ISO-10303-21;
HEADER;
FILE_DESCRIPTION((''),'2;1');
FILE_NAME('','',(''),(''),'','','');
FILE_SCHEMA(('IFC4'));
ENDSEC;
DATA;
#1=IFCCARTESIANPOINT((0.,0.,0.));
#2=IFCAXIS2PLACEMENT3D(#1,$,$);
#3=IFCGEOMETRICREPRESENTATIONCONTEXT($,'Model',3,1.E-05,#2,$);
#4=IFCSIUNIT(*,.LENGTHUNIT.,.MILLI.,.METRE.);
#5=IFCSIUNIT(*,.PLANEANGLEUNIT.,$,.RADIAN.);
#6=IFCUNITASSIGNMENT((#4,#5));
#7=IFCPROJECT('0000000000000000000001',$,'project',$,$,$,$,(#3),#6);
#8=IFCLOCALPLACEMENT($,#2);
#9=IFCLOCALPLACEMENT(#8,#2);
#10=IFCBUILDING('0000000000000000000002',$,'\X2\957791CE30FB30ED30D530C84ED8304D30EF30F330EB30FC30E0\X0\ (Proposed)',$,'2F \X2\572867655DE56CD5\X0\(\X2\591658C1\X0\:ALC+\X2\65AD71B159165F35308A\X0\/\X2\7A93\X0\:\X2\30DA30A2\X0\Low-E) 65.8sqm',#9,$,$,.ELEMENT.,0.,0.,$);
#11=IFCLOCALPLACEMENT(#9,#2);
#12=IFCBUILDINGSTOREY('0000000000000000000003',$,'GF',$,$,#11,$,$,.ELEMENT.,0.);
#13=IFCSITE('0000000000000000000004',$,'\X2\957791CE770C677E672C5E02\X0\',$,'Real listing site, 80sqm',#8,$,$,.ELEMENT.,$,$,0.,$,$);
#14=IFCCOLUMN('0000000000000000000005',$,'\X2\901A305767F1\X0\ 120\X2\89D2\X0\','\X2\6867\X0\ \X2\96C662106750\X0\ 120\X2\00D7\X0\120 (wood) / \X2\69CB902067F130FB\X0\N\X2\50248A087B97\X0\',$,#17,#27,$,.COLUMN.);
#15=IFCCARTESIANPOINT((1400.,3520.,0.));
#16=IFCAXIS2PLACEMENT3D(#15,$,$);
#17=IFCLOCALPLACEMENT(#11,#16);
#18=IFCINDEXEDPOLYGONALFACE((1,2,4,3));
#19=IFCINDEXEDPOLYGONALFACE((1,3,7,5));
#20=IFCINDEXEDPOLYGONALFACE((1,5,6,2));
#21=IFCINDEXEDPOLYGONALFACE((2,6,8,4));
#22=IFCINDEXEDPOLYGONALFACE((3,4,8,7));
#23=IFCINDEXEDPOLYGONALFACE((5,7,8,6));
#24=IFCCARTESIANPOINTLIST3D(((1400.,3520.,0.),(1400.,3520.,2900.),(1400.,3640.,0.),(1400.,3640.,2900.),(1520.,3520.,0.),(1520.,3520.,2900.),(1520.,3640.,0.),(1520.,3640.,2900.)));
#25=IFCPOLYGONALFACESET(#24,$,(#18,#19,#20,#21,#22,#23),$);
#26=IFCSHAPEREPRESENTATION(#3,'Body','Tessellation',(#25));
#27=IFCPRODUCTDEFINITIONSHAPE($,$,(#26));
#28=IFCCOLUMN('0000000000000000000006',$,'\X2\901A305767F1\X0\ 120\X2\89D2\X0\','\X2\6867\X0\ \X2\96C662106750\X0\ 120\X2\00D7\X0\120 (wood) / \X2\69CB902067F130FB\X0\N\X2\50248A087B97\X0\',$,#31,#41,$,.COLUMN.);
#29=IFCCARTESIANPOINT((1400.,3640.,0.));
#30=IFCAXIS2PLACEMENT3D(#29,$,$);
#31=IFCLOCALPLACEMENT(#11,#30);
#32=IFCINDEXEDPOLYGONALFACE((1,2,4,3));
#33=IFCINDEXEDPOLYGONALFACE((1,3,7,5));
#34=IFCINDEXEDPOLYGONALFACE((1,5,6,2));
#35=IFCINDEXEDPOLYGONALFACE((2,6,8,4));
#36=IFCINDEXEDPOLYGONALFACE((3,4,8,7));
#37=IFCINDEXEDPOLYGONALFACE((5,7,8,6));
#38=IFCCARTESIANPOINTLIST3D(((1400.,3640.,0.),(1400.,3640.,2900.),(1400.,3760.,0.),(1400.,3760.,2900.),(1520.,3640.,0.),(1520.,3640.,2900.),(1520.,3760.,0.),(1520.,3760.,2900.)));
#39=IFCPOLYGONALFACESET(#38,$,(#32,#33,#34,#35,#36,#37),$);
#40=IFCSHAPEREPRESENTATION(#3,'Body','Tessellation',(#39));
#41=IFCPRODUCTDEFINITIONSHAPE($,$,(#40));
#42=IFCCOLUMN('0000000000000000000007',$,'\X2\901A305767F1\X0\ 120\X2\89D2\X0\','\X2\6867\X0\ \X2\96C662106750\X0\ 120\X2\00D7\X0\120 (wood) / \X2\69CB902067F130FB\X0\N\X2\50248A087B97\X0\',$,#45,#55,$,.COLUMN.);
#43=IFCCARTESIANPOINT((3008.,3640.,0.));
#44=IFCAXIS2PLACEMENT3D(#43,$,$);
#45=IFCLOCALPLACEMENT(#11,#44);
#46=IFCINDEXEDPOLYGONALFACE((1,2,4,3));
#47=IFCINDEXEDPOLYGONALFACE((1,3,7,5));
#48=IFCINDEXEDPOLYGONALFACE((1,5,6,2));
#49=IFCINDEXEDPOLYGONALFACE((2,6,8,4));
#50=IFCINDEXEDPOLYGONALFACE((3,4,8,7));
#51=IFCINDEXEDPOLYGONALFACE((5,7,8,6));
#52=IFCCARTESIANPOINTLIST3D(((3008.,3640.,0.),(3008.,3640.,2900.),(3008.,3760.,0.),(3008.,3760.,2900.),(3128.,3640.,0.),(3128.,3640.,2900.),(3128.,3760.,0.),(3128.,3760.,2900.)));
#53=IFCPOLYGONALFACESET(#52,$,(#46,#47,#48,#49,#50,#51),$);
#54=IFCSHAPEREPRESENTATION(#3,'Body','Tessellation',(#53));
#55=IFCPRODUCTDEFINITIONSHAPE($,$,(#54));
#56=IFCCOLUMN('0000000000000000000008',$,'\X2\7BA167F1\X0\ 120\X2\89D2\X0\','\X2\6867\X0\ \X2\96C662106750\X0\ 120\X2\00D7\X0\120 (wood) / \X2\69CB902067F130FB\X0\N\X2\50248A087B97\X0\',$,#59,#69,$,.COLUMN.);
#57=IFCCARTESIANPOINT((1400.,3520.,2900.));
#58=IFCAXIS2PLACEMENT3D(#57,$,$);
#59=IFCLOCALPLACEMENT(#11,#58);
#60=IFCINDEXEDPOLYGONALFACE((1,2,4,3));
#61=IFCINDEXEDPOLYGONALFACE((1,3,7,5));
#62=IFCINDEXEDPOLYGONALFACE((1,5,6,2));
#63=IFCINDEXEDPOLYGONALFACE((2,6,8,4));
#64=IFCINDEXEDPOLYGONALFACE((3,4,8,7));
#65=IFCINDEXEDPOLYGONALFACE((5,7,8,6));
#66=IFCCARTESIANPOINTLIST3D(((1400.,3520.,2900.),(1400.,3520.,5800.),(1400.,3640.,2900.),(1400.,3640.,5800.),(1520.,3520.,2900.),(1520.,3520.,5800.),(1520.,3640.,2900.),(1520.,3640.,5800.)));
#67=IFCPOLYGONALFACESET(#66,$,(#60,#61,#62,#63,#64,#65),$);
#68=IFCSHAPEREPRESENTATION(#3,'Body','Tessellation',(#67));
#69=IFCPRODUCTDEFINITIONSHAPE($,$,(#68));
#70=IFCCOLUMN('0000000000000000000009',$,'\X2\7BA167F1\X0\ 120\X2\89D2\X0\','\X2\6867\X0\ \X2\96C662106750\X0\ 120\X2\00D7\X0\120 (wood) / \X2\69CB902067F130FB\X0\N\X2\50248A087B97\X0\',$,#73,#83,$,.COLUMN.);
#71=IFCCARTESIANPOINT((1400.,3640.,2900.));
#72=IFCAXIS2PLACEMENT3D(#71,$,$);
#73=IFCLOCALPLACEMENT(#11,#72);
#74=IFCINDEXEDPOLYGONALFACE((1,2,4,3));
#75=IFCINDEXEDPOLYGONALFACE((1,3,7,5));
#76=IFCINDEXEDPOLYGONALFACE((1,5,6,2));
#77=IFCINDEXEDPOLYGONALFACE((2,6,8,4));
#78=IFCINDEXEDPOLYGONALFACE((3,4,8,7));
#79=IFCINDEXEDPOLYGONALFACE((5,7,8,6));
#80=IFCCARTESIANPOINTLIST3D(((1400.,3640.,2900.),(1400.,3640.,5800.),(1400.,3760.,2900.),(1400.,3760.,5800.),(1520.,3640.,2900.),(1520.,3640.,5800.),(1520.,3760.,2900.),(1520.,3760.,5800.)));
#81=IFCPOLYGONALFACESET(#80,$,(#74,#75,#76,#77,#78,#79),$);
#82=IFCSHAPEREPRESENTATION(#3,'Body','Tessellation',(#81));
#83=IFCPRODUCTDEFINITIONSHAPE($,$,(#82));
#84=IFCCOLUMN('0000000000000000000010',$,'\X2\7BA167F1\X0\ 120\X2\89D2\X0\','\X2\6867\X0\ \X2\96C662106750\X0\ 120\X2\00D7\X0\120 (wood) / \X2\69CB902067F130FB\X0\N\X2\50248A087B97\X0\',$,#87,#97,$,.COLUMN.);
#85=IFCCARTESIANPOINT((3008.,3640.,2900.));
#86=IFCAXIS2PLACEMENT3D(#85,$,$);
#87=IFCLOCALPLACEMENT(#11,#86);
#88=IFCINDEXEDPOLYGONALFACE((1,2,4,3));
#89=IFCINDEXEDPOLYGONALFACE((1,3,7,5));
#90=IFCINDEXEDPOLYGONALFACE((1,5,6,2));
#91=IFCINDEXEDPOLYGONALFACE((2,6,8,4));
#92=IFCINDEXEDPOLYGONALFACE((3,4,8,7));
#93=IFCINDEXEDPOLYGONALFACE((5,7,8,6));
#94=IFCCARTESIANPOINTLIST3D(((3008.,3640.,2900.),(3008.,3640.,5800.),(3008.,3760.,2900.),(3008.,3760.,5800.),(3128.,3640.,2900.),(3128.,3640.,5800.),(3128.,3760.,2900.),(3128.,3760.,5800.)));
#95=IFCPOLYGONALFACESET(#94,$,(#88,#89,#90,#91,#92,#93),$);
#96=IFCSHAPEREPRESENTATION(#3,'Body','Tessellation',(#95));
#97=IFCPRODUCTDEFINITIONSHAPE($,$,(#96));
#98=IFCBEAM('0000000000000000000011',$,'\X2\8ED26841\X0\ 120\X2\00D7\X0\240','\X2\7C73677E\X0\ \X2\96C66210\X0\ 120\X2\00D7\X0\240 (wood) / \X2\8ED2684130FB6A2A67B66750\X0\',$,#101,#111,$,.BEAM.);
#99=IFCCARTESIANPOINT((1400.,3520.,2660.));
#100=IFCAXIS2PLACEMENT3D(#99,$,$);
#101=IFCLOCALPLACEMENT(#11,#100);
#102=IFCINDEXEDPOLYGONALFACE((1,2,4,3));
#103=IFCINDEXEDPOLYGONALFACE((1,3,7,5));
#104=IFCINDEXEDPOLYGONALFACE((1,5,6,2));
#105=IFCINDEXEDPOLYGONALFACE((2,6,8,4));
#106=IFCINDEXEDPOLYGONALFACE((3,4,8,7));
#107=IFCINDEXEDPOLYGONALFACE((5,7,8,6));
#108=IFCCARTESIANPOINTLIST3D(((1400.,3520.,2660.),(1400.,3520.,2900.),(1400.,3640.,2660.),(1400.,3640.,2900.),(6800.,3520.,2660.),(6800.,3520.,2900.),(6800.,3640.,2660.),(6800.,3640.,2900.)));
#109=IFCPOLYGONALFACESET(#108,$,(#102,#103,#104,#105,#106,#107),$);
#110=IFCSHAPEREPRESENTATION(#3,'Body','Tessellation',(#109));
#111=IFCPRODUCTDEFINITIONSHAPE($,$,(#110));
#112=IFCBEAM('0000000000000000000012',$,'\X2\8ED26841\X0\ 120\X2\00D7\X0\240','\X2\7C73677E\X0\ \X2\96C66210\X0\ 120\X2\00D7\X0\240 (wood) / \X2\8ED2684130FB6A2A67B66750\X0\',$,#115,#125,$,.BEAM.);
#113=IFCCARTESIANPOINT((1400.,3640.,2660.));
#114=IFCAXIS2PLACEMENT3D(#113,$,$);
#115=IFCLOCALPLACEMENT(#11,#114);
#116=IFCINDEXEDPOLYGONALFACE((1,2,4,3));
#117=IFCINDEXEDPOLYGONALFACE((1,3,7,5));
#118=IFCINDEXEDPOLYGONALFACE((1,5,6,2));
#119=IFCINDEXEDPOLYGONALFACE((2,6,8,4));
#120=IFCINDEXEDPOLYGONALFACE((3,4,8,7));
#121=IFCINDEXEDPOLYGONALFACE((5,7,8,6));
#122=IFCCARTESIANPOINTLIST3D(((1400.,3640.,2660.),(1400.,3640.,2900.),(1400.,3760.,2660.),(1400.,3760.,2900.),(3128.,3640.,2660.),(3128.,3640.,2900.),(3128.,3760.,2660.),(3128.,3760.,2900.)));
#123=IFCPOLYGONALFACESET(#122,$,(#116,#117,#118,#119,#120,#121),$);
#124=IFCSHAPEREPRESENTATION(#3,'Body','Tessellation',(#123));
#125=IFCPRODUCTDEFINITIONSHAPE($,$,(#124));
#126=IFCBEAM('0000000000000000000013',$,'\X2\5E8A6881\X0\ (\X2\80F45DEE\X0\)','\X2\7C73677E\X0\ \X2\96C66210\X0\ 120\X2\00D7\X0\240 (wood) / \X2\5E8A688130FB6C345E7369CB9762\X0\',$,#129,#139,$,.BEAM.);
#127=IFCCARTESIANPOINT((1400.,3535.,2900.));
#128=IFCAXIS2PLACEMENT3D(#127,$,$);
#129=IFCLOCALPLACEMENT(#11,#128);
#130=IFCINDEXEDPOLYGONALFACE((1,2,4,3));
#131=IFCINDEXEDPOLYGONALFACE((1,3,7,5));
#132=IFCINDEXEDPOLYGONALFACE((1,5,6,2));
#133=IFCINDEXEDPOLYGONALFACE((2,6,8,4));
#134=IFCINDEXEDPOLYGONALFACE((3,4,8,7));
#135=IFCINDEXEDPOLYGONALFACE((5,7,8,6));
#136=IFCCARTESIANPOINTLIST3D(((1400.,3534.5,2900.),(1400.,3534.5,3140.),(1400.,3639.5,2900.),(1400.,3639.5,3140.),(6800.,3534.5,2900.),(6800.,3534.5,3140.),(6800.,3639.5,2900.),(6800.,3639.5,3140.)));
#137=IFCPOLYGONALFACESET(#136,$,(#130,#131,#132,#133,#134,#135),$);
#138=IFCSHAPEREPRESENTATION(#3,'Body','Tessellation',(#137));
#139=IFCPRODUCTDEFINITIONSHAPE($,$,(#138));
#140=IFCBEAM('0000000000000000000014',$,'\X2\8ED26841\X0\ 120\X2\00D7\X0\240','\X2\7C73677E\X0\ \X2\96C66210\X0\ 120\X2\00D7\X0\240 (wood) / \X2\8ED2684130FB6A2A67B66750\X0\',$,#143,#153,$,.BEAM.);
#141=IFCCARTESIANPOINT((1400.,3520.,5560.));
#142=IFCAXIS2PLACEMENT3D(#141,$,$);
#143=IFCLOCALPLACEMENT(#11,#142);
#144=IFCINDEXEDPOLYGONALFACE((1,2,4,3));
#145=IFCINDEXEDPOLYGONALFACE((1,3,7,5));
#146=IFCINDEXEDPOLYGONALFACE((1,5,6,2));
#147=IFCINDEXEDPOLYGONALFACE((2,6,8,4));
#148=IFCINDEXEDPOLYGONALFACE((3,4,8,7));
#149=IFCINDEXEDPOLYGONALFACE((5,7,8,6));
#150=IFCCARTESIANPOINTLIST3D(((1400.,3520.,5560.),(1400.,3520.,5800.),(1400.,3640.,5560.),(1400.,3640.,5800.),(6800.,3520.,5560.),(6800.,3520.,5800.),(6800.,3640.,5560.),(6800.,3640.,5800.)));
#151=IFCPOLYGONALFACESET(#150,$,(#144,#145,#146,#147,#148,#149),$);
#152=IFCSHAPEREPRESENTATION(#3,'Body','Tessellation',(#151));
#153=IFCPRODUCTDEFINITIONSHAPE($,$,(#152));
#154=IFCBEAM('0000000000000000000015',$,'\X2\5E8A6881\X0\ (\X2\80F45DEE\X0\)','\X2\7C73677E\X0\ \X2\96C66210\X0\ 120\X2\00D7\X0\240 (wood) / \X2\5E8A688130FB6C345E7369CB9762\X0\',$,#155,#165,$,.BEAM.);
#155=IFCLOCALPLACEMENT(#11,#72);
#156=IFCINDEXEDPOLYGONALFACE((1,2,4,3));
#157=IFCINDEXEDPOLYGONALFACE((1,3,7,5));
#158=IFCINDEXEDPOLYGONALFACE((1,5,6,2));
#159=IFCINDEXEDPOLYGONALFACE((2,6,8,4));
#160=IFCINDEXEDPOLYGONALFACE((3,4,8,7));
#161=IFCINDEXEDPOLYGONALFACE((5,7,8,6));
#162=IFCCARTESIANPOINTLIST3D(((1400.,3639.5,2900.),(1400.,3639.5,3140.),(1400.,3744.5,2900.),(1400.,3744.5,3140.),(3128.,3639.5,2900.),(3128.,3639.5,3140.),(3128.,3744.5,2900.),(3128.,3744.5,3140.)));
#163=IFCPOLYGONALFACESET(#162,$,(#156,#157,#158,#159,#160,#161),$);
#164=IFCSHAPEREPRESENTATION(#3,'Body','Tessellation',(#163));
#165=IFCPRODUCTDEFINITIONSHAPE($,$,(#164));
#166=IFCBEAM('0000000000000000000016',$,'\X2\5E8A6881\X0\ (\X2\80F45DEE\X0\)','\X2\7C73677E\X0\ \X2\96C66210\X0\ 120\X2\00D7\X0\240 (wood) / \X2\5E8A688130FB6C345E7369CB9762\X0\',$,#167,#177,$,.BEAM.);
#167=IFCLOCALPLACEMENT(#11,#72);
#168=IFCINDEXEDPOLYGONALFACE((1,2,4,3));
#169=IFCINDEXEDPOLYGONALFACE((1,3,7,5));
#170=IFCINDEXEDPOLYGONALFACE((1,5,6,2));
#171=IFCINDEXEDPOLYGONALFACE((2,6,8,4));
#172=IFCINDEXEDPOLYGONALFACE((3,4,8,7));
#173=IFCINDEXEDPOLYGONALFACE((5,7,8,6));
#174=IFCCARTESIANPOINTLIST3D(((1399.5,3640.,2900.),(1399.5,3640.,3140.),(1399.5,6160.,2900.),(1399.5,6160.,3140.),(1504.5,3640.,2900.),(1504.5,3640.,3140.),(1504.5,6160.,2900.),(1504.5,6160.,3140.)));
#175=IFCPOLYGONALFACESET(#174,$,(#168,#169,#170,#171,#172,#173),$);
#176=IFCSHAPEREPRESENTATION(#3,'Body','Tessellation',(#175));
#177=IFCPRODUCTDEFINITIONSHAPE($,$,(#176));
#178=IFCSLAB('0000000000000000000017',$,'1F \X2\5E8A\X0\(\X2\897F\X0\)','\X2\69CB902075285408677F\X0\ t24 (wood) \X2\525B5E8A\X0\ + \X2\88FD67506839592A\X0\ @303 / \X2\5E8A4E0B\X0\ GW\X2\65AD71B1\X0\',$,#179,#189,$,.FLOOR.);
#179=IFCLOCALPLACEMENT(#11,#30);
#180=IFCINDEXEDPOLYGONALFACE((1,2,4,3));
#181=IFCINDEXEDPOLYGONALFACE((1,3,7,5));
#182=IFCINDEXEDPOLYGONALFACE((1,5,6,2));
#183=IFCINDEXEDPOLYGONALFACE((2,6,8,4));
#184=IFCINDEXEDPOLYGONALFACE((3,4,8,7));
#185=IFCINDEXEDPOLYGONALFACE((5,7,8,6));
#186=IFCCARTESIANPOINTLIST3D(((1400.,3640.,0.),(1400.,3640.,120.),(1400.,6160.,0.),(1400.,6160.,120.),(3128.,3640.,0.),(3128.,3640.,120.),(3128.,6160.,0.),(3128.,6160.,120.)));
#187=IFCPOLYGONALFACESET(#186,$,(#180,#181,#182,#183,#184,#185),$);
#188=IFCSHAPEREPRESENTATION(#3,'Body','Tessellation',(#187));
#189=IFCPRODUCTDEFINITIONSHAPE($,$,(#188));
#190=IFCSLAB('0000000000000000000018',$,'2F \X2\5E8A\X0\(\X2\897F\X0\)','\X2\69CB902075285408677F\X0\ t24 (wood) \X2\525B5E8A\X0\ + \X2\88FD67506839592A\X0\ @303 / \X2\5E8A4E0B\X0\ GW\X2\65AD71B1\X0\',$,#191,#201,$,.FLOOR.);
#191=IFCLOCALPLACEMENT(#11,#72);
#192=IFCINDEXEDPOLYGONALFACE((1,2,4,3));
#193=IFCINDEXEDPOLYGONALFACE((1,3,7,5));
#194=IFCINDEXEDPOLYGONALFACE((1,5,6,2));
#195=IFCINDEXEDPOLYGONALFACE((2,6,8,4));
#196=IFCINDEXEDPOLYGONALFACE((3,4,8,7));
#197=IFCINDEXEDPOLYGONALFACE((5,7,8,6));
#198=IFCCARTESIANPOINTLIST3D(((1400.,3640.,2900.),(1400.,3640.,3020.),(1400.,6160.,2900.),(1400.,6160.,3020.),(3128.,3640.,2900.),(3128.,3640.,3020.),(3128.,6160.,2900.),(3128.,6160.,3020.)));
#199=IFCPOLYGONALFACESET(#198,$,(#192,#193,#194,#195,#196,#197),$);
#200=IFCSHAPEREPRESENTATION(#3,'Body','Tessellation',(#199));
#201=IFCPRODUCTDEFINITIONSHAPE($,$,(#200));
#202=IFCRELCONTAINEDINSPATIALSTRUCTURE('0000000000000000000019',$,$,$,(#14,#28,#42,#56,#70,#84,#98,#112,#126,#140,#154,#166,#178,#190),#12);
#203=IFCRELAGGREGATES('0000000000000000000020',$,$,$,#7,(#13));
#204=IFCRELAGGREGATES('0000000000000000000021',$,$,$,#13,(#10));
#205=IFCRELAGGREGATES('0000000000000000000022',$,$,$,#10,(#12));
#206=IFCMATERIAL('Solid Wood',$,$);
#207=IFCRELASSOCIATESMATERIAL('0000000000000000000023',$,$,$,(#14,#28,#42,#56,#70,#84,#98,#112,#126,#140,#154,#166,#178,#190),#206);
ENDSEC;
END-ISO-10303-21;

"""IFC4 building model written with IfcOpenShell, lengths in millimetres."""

from ifc_helpers import new_model, si_unit, frame, frame_2d, origin, place, context, project, spatial, rectangle, extrude, material, element, save


model = new_model("IFC4")

# Units and contexts
model_context = context("Model", 3, precision=1e-05, world=origin())
ifc_project = project(units=[si_unit("LENGTHUNIT", "METRE", prefix="MILLI"), si_unit("PLANEANGLEUNIT", "RADIAN")], contexts=[model_context])

# Site, building, storey
site_placement = place(None, origin())
site = spatial("IfcSite", under=ifc_project, at=site_placement, Name="長野県松本市", ObjectType="Real listing site, 80sqm", CompositionType="ELEMENT", RefElevation=0.0)
building_placement = place(site_placement, origin())
building = spatial("IfcBuilding", under=site, at=building_placement, Name="長野・ロフト付きワンルーム (Proposed)", ObjectType="2F 在来工法(外壁:ALC+断熱外張り/窓:ペアLow-E) 65.8sqm", CompositionType="ELEMENT", ElevationOfRefHeight=0.0, ElevationOfTerrain=0.0)
storey_placement = place(building_placement, origin())
storey = spatial("IfcBuildingStorey", under=building, at=storey_placement, Name="GF", CompositionType="ELEMENT", Elevation=0.0)

# Columns
ifc_material_1 = material(Name="Solid Wood")
column_1_placement = place(storey_placement, frame((1400.0, 3520.0, 0.0)))
element("IfcColumn", 1, at=column_1_placement, inside=storey, material=ifc_material_1, Name="通し柱 120角", Description="桧 集成材 120×120 (wood) / 構造柱・N値計算", PredefinedType="COLUMN", context=model_context, shape_type="SweptSolid", body=[
    extrude(rectangle(XDim=120.0, YDim=120.0, at=frame_2d((60.0, 60.0))), frame((1400.0, 3520.0, 0.0)), (0.0, 0.0, 1.0), 2900.0),
])
column_2_placement = place(storey_placement, frame((1400.0, 3640.0, 0.0)))
element("IfcColumn", 2, at=column_2_placement, inside=storey, material=ifc_material_1, Name="通し柱 120角", Description="桧 集成材 120×120 (wood) / 構造柱・N値計算", PredefinedType="COLUMN", context=model_context, shape_type="SweptSolid", body=[
    extrude(rectangle(XDim=120.0, YDim=120.0, at=frame_2d((60.0, 60.0))), frame((1400.0, 3640.0, 0.0)), (0.0, 0.0, 1.0), 2900.0),
])
column_3_placement = place(storey_placement, frame((3008.0, 3640.0, 0.0)))
element("IfcColumn", 3, at=column_3_placement, inside=storey, material=ifc_material_1, Name="通し柱 120角", Description="桧 集成材 120×120 (wood) / 構造柱・N値計算", PredefinedType="COLUMN", context=model_context, shape_type="SweptSolid", body=[
    extrude(rectangle(XDim=120.0, YDim=120.0, at=frame_2d((60.0, 60.0))), frame((3008.0, 3640.0, 0.0)), (0.0, 0.0, 1.0), 2900.0),
])
column_4_placement = place(storey_placement, frame((1400.0, 3520.0, 2900.0)))
element("IfcColumn", 4, at=column_4_placement, inside=storey, material=ifc_material_1, Name="管柱 120角", Description="桧 集成材 120×120 (wood) / 構造柱・N値計算", PredefinedType="COLUMN", context=model_context, shape_type="SweptSolid", body=[
    extrude(rectangle(XDim=120.0, YDim=120.0, at=frame_2d((60.0, 60.0))), frame((1400.0, 3520.0, 2900.0)), (0.0, 0.0, 1.0), 2900.0),
])
column_5_placement = place(storey_placement, frame((1400.0, 3640.0, 2900.0)))
element("IfcColumn", 5, at=column_5_placement, inside=storey, material=ifc_material_1, Name="管柱 120角", Description="桧 集成材 120×120 (wood) / 構造柱・N値計算", PredefinedType="COLUMN", context=model_context, shape_type="SweptSolid", body=[
    extrude(rectangle(XDim=120.0, YDim=120.0, at=frame_2d((60.0, 60.0))), frame((1400.0, 3640.0, 2900.0)), (0.0, 0.0, 1.0), 2900.0),
])
column_6_placement = place(storey_placement, frame((3008.0, 3640.0, 2900.0)))
element("IfcColumn", 6, at=column_6_placement, inside=storey, material=ifc_material_1, Name="管柱 120角", Description="桧 集成材 120×120 (wood) / 構造柱・N値計算", PredefinedType="COLUMN", context=model_context, shape_type="SweptSolid", body=[
    extrude(rectangle(XDim=120.0, YDim=120.0, at=frame_2d((60.0, 60.0))), frame((3008.0, 3640.0, 2900.0)), (0.0, 0.0, 1.0), 2900.0),
])

# Beams
beam_1_placement = place(storey_placement, frame((1400.0, 3520.0, 2660.0)))
element("IfcBeam", 7, at=beam_1_placement, inside=storey, material=ifc_material_1, Name="軒桁 120×240", Description="米松 集成 120×240 (wood) / 軒桁・横架材", PredefinedType="BEAM", context=model_context, shape_type="SweptSolid", body=[
    extrude(rectangle(XDim=5400.0, YDim=120.0, at=frame_2d((2700.0, 60.0))), frame((1400.0, 3520.0, 2660.0)), (0.0, 0.0, 1.0), 240.0),
])
beam_2_placement = place(storey_placement, frame((1400.0, 3640.0, 2660.0)))
element("IfcBeam", 8, at=beam_2_placement, inside=storey, material=ifc_material_1, Name="軒桁 120×240", Description="米松 集成 120×240 (wood) / 軒桁・横架材", PredefinedType="BEAM", context=model_context, shape_type="SweptSolid", body=[
    extrude(rectangle(XDim=1728.0, YDim=120.0, at=frame_2d((864.0, 60.0))), frame((1400.0, 3640.0, 2660.0)), (0.0, 0.0, 1.0), 240.0),
])
beam_3_placement = place(storey_placement, frame((1400.0, 3535.0, 2900.0)))
element("IfcBeam", 9, at=beam_3_placement, inside=storey, material=ifc_material_1, Name="床梁 (胴差)", Description="米松 集成 120×240 (wood) / 床梁・水平構面", PredefinedType="BEAM", context=model_context, shape_type="SweptSolid", body=[
    extrude(rectangle(XDim=5400.0, YDim=105.0, at=frame_2d((2700.0, 52.0))), frame((1400.0, 3535.0, 2900.0)), (0.0, 0.0, 1.0), 240.0),
])
beam_4_placement = place(storey_placement, frame((1400.0, 3520.0, 5560.0)))
element("IfcBeam", 10, at=beam_4_placement, inside=storey, material=ifc_material_1, Name="軒桁 120×240", Description="米松 集成 120×240 (wood) / 軒桁・横架材", PredefinedType="BEAM", context=model_context, shape_type="SweptSolid", body=[
    extrude(rectangle(XDim=5400.0, YDim=120.0, at=frame_2d((2700.0, 60.0))), frame((1400.0, 3520.0, 5560.0)), (0.0, 0.0, 1.0), 240.0),
])
beam_5_placement = place(storey_placement, frame((1400.0, 3640.0, 2900.0)))
element("IfcBeam", 11, at=beam_5_placement, inside=storey, material=ifc_material_1, Name="床梁 (胴差)", Description="米松 集成 120×240 (wood) / 床梁・水平構面", PredefinedType="BEAM", context=model_context, shape_type="SweptSolid", body=[
    extrude(rectangle(XDim=1728.0, YDim=105.0, at=frame_2d((864.0, 52.0))), frame((1400.0, 3640.0, 2900.0)), (0.0, 0.0, 1.0), 240.0),
])
beam_6_placement = place(storey_placement, frame((1400.0, 3640.0, 2900.0)))
element("IfcBeam", 12, at=beam_6_placement, inside=storey, material=ifc_material_1, Name="床梁 (胴差)", Description="米松 集成 120×240 (wood) / 床梁・水平構面", PredefinedType="BEAM", context=model_context, shape_type="SweptSolid", body=[
    extrude(rectangle(XDim=105.0, YDim=2520.0, at=frame_2d((52.0, 1260.0))), frame((1400.0, 3640.0, 2900.0)), (0.0, 0.0, 1.0), 240.0),
])

# Slabs
slab_1_placement = place(storey_placement, frame((1400.0, 3640.0, 0.0)))
element("IfcSlab", 13, at=slab_1_placement, inside=storey, material=ifc_material_1, Name="1F 床(西)", Description="構造用合板 t24 (wood) 剛床 + 製材根太 @303 / 床下 GW断熱", PredefinedType="FLOOR", context=model_context, shape_type="SweptSolid", body=[
    extrude(rectangle(XDim=1728.0, YDim=2520.0, at=frame_2d((864.0, 1260.0))), frame((1400.0, 3640.0, 0.0)), (0.0, 0.0, 1.0), 120.0),
])
slab_2_placement = place(storey_placement, frame((1400.0, 3640.0, 2900.0)))
element("IfcSlab", 14, at=slab_2_placement, inside=storey, material=ifc_material_1, Name="2F 床(西)", Description="構造用合板 t24 (wood) 剛床 + 製材根太 @303 / 床下 GW断熱", PredefinedType="FLOOR", context=model_context, shape_type="SweptSolid", body=[
    extrude(rectangle(XDim=1728.0, YDim=2520.0, at=frame_2d((864.0, 1260.0))), frame((1400.0, 3640.0, 2900.0)), (0.0, 0.0, 1.0), 120.0),
])

save(model, "model.ifc")
